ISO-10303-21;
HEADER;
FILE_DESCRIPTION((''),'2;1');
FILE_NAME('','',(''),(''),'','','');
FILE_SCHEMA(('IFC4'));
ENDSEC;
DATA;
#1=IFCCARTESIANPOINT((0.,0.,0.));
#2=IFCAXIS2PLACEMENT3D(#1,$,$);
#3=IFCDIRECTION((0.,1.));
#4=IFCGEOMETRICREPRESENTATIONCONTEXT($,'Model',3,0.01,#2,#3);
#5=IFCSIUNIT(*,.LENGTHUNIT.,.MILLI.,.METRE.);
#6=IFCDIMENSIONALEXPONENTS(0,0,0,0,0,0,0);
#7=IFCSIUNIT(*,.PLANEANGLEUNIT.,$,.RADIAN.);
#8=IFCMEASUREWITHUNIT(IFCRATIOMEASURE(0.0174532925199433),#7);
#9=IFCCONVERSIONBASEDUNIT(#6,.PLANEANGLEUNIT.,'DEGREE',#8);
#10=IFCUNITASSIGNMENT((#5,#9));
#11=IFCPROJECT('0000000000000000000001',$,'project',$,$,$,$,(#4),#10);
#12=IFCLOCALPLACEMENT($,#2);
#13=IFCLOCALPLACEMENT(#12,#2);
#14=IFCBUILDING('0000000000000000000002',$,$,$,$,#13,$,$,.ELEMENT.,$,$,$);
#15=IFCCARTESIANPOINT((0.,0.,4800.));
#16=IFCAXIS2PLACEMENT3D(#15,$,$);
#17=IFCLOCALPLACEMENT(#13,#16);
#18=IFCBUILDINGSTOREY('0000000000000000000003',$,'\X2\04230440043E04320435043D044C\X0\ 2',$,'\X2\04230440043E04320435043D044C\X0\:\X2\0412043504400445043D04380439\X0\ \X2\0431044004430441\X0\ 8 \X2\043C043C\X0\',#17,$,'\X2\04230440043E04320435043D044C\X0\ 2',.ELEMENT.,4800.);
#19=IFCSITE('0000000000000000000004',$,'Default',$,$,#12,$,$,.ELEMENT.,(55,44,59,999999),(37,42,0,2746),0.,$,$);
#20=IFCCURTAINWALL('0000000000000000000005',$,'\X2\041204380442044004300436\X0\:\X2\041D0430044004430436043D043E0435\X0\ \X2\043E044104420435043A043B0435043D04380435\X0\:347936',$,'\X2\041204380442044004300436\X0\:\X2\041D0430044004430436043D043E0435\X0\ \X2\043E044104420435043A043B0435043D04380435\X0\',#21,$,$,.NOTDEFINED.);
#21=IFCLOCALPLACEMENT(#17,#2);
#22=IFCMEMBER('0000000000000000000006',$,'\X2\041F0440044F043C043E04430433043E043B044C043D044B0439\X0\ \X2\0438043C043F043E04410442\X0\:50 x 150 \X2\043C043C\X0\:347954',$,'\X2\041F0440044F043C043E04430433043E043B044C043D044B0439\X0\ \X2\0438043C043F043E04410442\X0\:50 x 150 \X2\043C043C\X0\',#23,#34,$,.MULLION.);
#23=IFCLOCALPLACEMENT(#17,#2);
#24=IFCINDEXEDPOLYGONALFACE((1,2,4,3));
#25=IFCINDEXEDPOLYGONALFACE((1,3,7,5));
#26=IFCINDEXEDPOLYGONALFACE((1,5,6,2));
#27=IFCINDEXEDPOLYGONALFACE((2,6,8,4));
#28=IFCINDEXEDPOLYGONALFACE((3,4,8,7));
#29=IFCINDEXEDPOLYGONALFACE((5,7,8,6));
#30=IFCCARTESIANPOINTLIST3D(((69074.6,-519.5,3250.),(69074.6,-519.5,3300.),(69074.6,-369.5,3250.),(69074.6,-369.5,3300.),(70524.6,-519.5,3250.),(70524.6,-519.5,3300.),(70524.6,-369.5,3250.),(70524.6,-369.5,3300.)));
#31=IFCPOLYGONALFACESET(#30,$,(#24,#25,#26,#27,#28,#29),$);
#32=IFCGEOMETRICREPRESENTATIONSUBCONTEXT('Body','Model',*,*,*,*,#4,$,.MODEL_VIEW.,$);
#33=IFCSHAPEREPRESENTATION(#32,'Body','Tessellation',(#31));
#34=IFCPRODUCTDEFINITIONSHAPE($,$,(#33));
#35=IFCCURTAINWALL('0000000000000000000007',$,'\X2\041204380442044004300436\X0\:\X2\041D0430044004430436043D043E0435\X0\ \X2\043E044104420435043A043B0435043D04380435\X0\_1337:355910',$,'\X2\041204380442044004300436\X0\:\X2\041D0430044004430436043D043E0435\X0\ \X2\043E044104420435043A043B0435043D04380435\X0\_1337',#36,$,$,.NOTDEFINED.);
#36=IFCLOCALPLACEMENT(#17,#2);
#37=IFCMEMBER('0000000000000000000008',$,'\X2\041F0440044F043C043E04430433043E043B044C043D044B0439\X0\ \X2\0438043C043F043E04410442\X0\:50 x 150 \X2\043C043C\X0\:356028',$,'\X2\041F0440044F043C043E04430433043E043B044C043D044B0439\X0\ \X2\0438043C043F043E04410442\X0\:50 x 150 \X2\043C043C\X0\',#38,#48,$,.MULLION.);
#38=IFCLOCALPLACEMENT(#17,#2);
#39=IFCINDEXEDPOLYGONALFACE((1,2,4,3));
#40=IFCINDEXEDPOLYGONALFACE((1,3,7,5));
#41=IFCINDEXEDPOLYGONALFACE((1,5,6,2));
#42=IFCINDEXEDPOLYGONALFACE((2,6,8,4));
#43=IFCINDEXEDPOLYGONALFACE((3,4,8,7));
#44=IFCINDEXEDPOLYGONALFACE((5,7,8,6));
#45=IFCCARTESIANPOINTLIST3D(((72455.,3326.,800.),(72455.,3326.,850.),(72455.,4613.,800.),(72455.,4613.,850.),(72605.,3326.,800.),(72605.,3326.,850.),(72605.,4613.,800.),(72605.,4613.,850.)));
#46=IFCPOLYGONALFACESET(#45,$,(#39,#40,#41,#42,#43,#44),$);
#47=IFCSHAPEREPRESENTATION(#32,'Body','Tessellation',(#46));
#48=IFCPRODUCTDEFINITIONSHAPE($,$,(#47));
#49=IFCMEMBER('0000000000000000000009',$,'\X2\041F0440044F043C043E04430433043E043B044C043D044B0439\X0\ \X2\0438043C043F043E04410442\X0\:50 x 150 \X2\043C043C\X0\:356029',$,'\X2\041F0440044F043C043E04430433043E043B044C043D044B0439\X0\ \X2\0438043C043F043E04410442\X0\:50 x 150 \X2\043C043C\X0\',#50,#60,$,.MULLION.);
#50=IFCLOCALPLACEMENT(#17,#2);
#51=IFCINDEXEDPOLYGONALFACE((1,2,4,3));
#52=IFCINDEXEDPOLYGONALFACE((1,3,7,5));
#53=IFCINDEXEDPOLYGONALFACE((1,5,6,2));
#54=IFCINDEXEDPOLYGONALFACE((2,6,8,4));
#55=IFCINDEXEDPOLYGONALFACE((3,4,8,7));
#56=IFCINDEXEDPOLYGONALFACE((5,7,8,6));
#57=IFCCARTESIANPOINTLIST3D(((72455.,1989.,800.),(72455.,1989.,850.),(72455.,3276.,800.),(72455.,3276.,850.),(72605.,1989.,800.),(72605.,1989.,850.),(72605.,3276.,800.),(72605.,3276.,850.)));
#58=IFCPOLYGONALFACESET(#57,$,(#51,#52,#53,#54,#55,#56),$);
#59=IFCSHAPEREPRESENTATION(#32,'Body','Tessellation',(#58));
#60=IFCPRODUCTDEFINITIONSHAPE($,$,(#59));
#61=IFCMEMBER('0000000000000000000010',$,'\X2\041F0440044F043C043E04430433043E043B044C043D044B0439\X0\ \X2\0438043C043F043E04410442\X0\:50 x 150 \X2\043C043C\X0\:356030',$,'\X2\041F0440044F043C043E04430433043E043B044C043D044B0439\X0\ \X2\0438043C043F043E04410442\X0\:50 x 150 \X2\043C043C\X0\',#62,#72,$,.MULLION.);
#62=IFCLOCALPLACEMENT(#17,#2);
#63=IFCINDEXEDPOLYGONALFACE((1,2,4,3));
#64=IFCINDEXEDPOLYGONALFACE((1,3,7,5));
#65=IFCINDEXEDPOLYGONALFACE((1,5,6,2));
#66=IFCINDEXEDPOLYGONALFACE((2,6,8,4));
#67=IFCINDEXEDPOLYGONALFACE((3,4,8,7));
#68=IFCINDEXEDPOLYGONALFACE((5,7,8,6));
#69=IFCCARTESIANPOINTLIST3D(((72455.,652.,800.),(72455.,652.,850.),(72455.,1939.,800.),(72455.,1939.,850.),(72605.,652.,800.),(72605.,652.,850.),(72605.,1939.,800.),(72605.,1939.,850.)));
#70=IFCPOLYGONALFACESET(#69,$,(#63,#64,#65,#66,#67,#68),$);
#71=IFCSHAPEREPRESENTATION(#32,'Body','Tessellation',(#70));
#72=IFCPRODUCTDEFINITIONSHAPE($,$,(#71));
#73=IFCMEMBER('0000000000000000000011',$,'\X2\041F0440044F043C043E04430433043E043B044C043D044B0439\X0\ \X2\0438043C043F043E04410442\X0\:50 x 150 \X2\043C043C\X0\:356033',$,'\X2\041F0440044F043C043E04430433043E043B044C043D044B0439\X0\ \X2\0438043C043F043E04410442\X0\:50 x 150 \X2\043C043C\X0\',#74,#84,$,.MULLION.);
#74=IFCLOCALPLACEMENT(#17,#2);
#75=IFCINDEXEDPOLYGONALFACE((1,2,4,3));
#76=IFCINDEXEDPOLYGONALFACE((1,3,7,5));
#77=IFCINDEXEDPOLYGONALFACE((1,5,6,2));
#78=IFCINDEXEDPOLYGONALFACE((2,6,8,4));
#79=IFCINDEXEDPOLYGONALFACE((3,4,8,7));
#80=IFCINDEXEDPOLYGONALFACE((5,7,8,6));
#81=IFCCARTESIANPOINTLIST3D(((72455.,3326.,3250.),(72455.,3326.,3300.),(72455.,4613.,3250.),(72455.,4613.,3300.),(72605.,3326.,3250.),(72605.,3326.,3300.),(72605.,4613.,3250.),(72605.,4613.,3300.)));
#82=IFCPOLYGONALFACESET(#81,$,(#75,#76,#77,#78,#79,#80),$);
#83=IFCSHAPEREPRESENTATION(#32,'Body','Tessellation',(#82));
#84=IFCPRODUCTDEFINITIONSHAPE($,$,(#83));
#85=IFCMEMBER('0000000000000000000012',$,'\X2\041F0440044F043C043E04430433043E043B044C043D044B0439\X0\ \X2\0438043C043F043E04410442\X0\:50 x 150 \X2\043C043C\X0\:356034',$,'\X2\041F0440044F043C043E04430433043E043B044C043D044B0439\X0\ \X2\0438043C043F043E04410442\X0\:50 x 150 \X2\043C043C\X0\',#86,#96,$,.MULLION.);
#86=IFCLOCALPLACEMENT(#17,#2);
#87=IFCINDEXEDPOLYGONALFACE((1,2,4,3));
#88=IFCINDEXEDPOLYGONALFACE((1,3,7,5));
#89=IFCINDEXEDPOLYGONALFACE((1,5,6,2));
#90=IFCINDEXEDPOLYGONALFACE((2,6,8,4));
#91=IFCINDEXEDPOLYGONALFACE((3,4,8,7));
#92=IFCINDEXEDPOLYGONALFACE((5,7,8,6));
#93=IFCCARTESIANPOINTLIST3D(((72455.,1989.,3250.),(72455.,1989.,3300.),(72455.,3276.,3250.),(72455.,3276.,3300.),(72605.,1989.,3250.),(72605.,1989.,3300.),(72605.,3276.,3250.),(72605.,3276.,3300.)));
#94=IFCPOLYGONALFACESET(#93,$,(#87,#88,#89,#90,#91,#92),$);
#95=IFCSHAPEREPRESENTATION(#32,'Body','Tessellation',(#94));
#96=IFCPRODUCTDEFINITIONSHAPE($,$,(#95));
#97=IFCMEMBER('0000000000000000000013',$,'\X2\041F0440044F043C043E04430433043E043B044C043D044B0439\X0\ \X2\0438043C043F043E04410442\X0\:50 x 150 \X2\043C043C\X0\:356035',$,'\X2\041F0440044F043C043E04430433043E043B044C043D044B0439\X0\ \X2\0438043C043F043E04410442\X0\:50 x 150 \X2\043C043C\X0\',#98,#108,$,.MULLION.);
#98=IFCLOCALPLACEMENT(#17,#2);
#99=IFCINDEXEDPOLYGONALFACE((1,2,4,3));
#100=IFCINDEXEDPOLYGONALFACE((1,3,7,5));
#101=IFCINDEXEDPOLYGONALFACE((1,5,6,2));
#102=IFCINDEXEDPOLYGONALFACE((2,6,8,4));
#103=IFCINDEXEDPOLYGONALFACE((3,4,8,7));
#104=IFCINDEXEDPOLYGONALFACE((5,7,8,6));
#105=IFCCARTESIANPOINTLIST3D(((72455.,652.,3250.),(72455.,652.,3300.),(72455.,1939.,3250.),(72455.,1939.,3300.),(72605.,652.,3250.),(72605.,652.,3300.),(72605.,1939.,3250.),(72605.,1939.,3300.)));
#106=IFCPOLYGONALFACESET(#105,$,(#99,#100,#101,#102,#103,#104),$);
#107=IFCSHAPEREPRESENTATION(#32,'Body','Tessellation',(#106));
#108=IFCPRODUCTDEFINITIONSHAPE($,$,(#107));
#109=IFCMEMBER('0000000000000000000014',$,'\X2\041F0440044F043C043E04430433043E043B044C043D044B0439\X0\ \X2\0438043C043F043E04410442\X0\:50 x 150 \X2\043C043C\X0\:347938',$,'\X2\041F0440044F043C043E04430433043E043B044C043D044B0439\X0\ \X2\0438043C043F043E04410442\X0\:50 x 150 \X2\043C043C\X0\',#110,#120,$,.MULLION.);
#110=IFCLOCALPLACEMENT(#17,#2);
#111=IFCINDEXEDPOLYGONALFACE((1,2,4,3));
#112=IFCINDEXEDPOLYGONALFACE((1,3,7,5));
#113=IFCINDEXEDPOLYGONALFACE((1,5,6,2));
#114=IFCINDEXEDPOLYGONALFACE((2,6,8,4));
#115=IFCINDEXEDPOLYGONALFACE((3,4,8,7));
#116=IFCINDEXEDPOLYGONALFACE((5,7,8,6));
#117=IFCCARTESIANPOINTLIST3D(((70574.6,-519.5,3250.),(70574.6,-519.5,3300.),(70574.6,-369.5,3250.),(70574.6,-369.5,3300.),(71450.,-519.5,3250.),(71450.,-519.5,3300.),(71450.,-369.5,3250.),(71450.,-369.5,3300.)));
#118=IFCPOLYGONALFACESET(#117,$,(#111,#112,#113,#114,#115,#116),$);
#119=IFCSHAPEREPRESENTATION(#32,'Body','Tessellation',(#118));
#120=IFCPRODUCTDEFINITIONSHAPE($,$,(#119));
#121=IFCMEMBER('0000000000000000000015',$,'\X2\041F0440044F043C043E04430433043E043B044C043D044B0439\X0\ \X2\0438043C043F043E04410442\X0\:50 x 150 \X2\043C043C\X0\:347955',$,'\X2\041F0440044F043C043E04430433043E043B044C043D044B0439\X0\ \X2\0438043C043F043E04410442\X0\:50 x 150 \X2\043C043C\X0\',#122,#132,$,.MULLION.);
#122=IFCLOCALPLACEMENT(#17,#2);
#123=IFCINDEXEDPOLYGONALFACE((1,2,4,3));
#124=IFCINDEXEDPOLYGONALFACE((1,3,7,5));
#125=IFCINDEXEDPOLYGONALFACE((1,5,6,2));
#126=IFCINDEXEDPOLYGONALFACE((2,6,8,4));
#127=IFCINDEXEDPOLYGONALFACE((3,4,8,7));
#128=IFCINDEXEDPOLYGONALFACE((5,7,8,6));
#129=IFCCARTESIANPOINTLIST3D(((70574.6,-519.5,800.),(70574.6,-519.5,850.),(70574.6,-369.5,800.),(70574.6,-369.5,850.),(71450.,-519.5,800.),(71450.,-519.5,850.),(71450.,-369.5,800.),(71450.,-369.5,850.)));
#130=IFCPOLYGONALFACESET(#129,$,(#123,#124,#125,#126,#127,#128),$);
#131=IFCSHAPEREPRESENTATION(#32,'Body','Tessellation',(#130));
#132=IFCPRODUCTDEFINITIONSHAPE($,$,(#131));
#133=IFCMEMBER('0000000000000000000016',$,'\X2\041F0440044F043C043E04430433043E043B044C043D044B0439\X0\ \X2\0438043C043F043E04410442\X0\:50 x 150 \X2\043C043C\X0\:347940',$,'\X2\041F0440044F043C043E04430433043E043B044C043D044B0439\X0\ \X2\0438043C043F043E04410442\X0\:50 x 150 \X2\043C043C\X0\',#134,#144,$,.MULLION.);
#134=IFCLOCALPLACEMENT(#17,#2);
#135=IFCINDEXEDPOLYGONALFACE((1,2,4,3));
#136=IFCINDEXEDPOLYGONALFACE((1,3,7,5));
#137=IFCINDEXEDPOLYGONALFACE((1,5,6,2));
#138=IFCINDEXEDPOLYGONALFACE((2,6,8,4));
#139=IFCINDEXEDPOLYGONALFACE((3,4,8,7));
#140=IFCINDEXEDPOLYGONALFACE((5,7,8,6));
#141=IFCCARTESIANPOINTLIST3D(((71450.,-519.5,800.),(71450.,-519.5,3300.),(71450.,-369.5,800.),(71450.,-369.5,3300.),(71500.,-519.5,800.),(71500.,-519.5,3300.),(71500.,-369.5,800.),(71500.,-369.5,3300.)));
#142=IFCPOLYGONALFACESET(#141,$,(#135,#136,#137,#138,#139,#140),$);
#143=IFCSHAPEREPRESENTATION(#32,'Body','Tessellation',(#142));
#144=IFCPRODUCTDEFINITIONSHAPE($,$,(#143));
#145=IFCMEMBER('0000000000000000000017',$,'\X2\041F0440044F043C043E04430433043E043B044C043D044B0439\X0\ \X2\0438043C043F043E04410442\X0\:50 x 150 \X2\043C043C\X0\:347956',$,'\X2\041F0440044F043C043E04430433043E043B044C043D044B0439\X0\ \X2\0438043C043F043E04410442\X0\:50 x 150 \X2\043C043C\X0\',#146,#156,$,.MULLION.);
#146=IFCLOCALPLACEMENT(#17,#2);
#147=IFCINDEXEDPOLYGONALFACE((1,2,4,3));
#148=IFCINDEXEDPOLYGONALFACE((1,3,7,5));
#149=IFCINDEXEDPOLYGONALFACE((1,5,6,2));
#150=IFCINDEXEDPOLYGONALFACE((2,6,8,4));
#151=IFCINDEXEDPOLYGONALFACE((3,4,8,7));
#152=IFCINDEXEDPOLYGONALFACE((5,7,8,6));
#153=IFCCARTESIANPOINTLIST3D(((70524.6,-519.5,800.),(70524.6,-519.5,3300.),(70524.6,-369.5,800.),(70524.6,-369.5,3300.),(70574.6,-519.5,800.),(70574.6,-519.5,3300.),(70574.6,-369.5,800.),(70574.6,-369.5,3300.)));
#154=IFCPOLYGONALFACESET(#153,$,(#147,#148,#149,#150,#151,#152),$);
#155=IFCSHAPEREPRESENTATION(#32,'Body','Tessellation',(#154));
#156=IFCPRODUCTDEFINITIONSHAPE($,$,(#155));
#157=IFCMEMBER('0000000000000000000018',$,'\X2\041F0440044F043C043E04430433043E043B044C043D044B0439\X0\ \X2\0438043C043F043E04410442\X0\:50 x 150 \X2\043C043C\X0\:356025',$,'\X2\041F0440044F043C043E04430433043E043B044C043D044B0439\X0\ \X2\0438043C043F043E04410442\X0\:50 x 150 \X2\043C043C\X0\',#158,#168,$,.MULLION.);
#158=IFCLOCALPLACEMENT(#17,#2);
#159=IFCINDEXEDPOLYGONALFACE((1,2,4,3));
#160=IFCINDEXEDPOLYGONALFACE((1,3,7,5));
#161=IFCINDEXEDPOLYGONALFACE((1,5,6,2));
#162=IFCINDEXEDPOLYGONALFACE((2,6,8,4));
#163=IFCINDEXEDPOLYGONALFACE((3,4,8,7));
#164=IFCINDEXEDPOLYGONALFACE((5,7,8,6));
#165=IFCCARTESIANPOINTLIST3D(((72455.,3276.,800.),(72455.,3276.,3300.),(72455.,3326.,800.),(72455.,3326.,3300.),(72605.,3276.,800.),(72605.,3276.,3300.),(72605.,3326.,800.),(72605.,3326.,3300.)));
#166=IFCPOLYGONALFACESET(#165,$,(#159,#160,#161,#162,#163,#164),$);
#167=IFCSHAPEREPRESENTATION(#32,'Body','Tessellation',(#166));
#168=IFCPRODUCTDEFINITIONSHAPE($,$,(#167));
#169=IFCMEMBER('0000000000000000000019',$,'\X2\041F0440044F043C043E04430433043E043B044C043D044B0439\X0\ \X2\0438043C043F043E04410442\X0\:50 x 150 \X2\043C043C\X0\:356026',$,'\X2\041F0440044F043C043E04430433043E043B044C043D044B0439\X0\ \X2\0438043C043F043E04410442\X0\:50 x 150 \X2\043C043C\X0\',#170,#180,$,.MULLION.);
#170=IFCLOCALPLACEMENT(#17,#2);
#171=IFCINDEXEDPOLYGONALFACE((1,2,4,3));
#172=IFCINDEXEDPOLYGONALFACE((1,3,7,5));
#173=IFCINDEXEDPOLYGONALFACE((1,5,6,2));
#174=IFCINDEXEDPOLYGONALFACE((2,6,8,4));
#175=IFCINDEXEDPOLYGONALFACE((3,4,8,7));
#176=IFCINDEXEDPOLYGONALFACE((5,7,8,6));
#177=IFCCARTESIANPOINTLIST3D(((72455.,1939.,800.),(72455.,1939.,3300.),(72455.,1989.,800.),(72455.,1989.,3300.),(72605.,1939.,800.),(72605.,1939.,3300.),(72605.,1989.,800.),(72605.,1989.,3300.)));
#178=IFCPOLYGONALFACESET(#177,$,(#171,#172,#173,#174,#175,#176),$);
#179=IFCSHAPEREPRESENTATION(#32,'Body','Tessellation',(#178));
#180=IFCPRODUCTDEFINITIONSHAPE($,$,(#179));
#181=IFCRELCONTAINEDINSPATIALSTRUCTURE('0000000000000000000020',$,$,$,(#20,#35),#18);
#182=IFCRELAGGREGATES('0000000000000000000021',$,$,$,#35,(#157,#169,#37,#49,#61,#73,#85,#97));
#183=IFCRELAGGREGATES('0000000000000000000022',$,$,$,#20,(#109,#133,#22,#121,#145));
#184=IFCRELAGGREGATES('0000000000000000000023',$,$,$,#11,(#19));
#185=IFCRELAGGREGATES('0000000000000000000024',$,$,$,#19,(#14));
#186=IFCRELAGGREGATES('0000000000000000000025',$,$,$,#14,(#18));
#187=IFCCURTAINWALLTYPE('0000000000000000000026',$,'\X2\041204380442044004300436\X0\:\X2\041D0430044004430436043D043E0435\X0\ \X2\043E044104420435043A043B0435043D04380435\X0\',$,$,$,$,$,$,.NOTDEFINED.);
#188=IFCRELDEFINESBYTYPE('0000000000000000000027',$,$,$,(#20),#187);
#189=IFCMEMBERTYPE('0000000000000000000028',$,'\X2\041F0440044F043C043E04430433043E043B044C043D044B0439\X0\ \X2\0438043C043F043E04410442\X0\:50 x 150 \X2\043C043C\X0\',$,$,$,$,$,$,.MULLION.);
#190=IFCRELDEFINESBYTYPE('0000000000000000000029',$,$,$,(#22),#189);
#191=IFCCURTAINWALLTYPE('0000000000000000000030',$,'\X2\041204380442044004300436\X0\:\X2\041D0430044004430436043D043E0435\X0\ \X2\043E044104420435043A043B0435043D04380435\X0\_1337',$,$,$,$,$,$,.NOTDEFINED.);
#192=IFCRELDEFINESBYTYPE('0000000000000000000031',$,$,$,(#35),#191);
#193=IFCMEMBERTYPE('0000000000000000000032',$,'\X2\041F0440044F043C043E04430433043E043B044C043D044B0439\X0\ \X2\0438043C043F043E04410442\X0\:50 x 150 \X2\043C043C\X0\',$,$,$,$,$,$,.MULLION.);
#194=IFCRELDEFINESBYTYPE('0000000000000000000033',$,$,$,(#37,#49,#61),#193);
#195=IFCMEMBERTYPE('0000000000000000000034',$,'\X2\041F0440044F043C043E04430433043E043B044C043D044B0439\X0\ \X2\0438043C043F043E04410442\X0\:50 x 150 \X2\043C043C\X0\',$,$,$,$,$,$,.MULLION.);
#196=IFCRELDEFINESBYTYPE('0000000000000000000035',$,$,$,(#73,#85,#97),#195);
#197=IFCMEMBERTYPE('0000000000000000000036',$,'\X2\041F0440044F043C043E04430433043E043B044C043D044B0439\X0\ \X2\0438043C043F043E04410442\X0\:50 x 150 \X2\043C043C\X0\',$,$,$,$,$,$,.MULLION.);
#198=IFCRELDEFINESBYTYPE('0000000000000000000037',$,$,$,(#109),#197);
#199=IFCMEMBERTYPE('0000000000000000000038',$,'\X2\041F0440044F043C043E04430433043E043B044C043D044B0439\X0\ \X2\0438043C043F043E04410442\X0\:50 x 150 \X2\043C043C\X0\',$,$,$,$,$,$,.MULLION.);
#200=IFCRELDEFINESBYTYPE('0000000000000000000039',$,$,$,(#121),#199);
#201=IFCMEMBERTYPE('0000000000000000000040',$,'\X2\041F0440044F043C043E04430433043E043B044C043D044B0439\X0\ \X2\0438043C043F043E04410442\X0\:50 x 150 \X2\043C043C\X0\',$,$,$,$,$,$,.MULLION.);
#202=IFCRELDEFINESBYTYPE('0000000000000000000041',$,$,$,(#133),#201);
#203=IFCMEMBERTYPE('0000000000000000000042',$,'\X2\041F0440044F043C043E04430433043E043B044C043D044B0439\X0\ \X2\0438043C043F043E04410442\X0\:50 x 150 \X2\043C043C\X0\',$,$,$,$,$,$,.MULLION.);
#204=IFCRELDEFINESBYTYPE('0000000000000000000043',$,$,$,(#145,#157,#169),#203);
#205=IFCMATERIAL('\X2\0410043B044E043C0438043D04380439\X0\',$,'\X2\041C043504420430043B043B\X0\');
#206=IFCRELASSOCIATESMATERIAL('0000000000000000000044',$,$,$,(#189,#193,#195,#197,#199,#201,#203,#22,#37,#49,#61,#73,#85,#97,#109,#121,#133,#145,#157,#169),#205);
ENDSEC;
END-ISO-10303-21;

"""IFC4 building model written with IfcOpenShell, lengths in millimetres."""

from ifc_helpers import new_model, entity, si_unit, converted_unit, direction, frame, origin, origin_2d_with_axis, place, context, subcontext, project, spatial, rectangle, extrude, source, transform, mapped, material, material_profile, profile_set, profile_usage, type_object, type_shapes, element, aggregate, save


model = new_model("IFC4")

# Units and contexts
model_context = context("Model", 3, precision=0.01, world=origin(), true_north=direction((0.0, 1.0)))
body_context = subcontext(model_context, "Body", "Model", "MODEL_VIEW")
ifc_project = project(units=[si_unit("LENGTHUNIT", "METRE", prefix="MILLI"), converted_unit("PLANEANGLEUNIT", "DEGREE", entity("IfcRatioMeasure", 0.0174532925199433), si_unit("PLANEANGLEUNIT", "RADIAN"), dimensions=[0, 0, 0, 0, 0, 0, 0])], contexts=[model_context])

# Site, building, storey
site_placement = place(None, origin())
site = spatial("IfcSite", under=ifc_project, at=site_placement, Name="Default", CompositionType="ELEMENT", RefLatitude=(55, 44, 59, 999999), RefLongitude=(37, 42, 0, 2746), RefElevation=0.0)
building_placement = place(site_placement, origin())
building = spatial("IfcBuilding", under=site, at=building_placement, CompositionType="ELEMENT")
storey_placement = place(building_placement, frame((0.0, 0.0, 4800.0)))
storey = spatial("IfcBuildingStorey", under=building, at=storey_placement, Name="Уровень 2", ObjectType="Уровень:Верхний брус 8 мм", LongName="Уровень 2", CompositionType="ELEMENT", Elevation=4800.0)

# Curtain wall, member
curtain_wall_type_1 = type_object("IfcCurtainWallType", Name="Витраж:Наружное остекление", PredefinedType="NOTDEFINED")
curtain_wall_1_placement = place(storey_placement, frame((0.0, 0.0, -4800.0)))
curtain_wall_1 = element("IfcCurtainWall", 1, at=curtain_wall_1_placement, inside=storey, type_object=curtain_wall_type_1, Name="Витраж:Наружное остекление:347936", ObjectType="Витраж:Наружное остекление", PredefinedType="NOTDEFINED")
ifc_material_1 = material(Name="Алюминий", Category="Металл")
ifc_material_profile = material_profile(ifc_material_1, rectangle(XDim=150.0, YDim=50.0, at=origin_2d_with_axis()), Name="50 x 150 мм")
ifc_profile_set = profile_set([ifc_material_profile], Name="50 x 150 мм")
ifc_profile_usage_1 = profile_usage(ifc_profile_set)
member_type_1 = type_object("IfcMemberType", Name="Прямоугольный импост:50 x 150 мм", PredefinedType="MULLION", material=ifc_profile_set)
shared_shape_1 = source(origin(), body_context, "Body", "SweptSolid", [
    extrude(rectangle(XDim=150.0, YDim=50.0, at=origin_2d_with_axis()), frame((-25.0, 0.0, -1450.0), z_axis=(0.0, 0.0, 1.0), x_axis=(0.0, -1.0, 0.0)), (0.0, 0.0, 1.0), 1450.0),
])
type_shapes(member_type_1, [shared_shape_1])
member_1_placement = place(storey_placement, frame((70524.6, -444.5, 3300.0), z_axis=(1.0, 0.0, 0.0), x_axis=(0.0, 0.0, 1.0)))
member_1 = element("IfcMember", 2, at=member_1_placement, type_object=member_type_1, material=ifc_profile_usage_1, Name="Прямоугольный импост:50 x 150 мм:347954", ObjectType="Прямоугольный импост:50 x 150 мм", PredefinedType="MULLION", context=body_context, shape_type="MappedRepresentation", body=[
    mapped(shared_shape_1, transform((0.0, 0.0, 0.0), scale=1.0)),
])

# Curtain wall, members
curtain_wall_type_2 = type_object("IfcCurtainWallType", Name="Витраж:Наружное остекление_1337", PredefinedType="NOTDEFINED")
curtain_wall_2_placement = place(storey_placement, frame((0.0, 0.0, -4800.0)))
curtain_wall_2 = element("IfcCurtainWall", 3, at=curtain_wall_2_placement, inside=storey, type_object=curtain_wall_type_2, Name="Витраж:Наружное остекление_1337:355910", ObjectType="Витраж:Наружное остекление_1337", PredefinedType="NOTDEFINED")
ifc_profile_usage_2 = profile_usage(ifc_profile_set)
member_type_2 = type_object("IfcMemberType", Name="Прямоугольный импост:50 x 150 мм", PredefinedType="MULLION", material=ifc_profile_set)
shared_shape_2 = source(origin(), body_context, "Body", "SweptSolid", [
    extrude(rectangle(XDim=150.0, YDim=50.0, at=origin_2d_with_axis()), frame((-25.0, 0.0, -1287.0), z_axis=(0.0, 0.0, 1.0), x_axis=(0.0, -1.0, 0.0)), (0.0, 0.0, 1.0), 1287.0),
])
type_shapes(member_type_2, [shared_shape_2])
member_2_placement = place(storey_placement, frame((72530.0, 4613.0, 800.0), z_axis=(0.0, 1.0, 0.0), x_axis=(0.0, 0.0, -1.0)))
member_2 = element("IfcMember", 4, at=member_2_placement, type_object=member_type_2, material=ifc_profile_usage_2, Name="Прямоугольный импост:50 x 150 мм:356028", ObjectType="Прямоугольный импост:50 x 150 мм", PredefinedType="MULLION", context=body_context, shape_type="MappedRepresentation", body=[
    mapped(shared_shape_2, transform((0.0, 0.0, 0.0), scale=1.0)),
])
ifc_profile_usage_3 = profile_usage(ifc_profile_set)
member_3_placement = place(storey_placement, frame((72530.0, 3276.0, 800.0), z_axis=(0.0, 1.0, 0.0), x_axis=(0.0, 0.0, -1.0)))
member_3 = element("IfcMember", 5, at=member_3_placement, type_object=member_type_2, material=ifc_profile_usage_3, Name="Прямоугольный импост:50 x 150 мм:356029", ObjectType="Прямоугольный импост:50 x 150 мм", PredefinedType="MULLION", context=body_context, shape_type="MappedRepresentation", body=[
    mapped(shared_shape_2, transform((0.0, 0.0, 0.0), scale=1.0)),
])
ifc_profile_usage_4 = profile_usage(ifc_profile_set)
member_4_placement = place(storey_placement, frame((72530.0, 1939.0, 800.0), z_axis=(0.0, 1.0, 0.0), x_axis=(0.0, 0.0, -1.0)))
member_4 = element("IfcMember", 6, at=member_4_placement, type_object=member_type_2, material=ifc_profile_usage_4, Name="Прямоугольный импост:50 x 150 мм:356030", ObjectType="Прямоугольный импост:50 x 150 мм", PredefinedType="MULLION", context=body_context, shape_type="MappedRepresentation", body=[
    mapped(shared_shape_2, transform((0.0, 0.0, 0.0), scale=1.0)),
])
ifc_profile_usage_5 = profile_usage(ifc_profile_set)
member_type_3 = type_object("IfcMemberType", Name="Прямоугольный импост:50 x 150 мм", PredefinedType="MULLION", material=ifc_profile_set)
shared_shape_3 = source(origin(), body_context, "Body", "SweptSolid", [
    extrude(rectangle(XDim=150.0, YDim=50.0, at=origin_2d_with_axis()), frame((-25.0, 0.0, -1287.0), z_axis=(0.0, 0.0, 1.0), x_axis=(0.0, -1.0, 0.0)), (0.0, 0.0, 1.0), 1287.0),
])
type_shapes(member_type_3, [shared_shape_3])
member_5_placement = place(storey_placement, frame((72530.0, 3326.0, 3300.0), z_axis=(0.0, -1.0, 0.0), x_axis=(0.0, 0.0, 1.0)))
member_5 = element("IfcMember", 7, at=member_5_placement, type_object=member_type_3, material=ifc_profile_usage_5, Name="Прямоугольный импост:50 x 150 мм:356033", ObjectType="Прямоугольный импост:50 x 150 мм", PredefinedType="MULLION", context=body_context, shape_type="MappedRepresentation", body=[
    mapped(shared_shape_3, transform((0.0, 0.0, 0.0), scale=1.0)),
])
ifc_profile_usage_6 = profile_usage(ifc_profile_set)
member_6_placement = place(storey_placement, frame((72530.0, 1989.0, 3300.0), z_axis=(0.0, -1.0, 0.0), x_axis=(0.0, 0.0, 1.0)))
member_6 = element("IfcMember", 8, at=member_6_placement, type_object=member_type_3, material=ifc_profile_usage_6, Name="Прямоугольный импост:50 x 150 мм:356034", ObjectType="Прямоугольный импост:50 x 150 мм", PredefinedType="MULLION", context=body_context, shape_type="MappedRepresentation", body=[
    mapped(shared_shape_3, transform((0.0, 0.0, 0.0), scale=1.0)),
])
ifc_profile_usage_7 = profile_usage(ifc_profile_set)
member_7_placement = place(storey_placement, frame((72530.0, 652.0, 3300.0), z_axis=(0.0, -1.0, 0.0), x_axis=(0.0, 0.0, 1.0)))
member_7 = element("IfcMember", 9, at=member_7_placement, type_object=member_type_3, material=ifc_profile_usage_7, Name="Прямоугольный импост:50 x 150 мм:356035", ObjectType="Прямоугольный импост:50 x 150 мм", PredefinedType="MULLION", context=body_context, shape_type="MappedRepresentation", body=[
    mapped(shared_shape_3, transform((0.0, 0.0, 0.0), scale=1.0)),
])

# Members
ifc_profile_usage_8 = profile_usage(ifc_profile_set)
member_type_4 = type_object("IfcMemberType", Name="Прямоугольный импост:50 x 150 мм", PredefinedType="MULLION", material=ifc_profile_set)
shared_shape_4 = source(origin(), body_context, "Body", "SweptSolid", [
    extrude(rectangle(XDim=150.0, YDim=50.0, at=origin_2d_with_axis()), frame((-25.0, 0.0, -875.4), z_axis=(0.0, 0.0, 1.0), x_axis=(0.0, -1.0, 0.0)), (0.0, 0.0, 1.0), 875.4),
])
type_shapes(member_type_4, [shared_shape_4])
member_8_placement = place(storey_placement, frame((71450.0, -444.5, 3300.0), z_axis=(1.0, 0.0, 0.0), x_axis=(0.0, 0.0, 1.0)))
member_8 = element("IfcMember", 10, at=member_8_placement, type_object=member_type_4, material=ifc_profile_usage_8, Name="Прямоугольный импост:50 x 150 мм:347938", ObjectType="Прямоугольный импост:50 x 150 мм", PredefinedType="MULLION", context=body_context, shape_type="MappedRepresentation", body=[
    mapped(shared_shape_4, transform((0.0, 0.0, 0.0), scale=1.0)),
])
ifc_profile_usage_9 = profile_usage(ifc_profile_set)
member_type_5 = type_object("IfcMemberType", Name="Прямоугольный импост:50 x 150 мм", PredefinedType="MULLION", material=ifc_profile_set)
shared_shape_5 = source(origin(), body_context, "Body", "SweptSolid", [
    extrude(rectangle(XDim=150.0, YDim=50.0, at=origin_2d_with_axis()), frame((-25.0, 0.0, -875.4), z_axis=(0.0, 0.0, 1.0), x_axis=(0.0, -1.0, 0.0)), (0.0, 0.0, 1.0), 875.4),
])
type_shapes(member_type_5, [shared_shape_5])
member_9_placement = place(storey_placement, frame((70574.6, -444.5, 800.0), z_axis=(-1.0, 0.0, 0.0), x_axis=(0.0, 0.0, -1.0)))
member_9 = element("IfcMember", 11, at=member_9_placement, type_object=member_type_5, material=ifc_profile_usage_9, Name="Прямоугольный импост:50 x 150 мм:347955", ObjectType="Прямоугольный импост:50 x 150 мм", PredefinedType="MULLION", context=body_context, shape_type="MappedRepresentation", body=[
    mapped(shared_shape_5, transform((0.0, 0.0, 0.0), scale=1.0)),
])
ifc_profile_usage_10 = profile_usage(ifc_profile_set)
member_type_6 = type_object("IfcMemberType", Name="Прямоугольный импост:50 x 150 мм", PredefinedType="MULLION", material=ifc_profile_set)
shared_shape_6 = source(origin(), body_context, "Body", "SweptSolid", [
    extrude(rectangle(XDim=150.0, YDim=50.0, at=origin_2d_with_axis()), frame((-25.0, 0.0, -2500.0), z_axis=(0.0, 0.0, 1.0), x_axis=(0.0, -1.0, 0.0)), (0.0, 0.0, 1.0), 2500.0),
])
type_shapes(member_type_6, [shared_shape_6])
member_10_placement = place(storey_placement, frame((71500.0, -444.5, 800.0), z_axis=(0.0, 0.0, -1.0), x_axis=(1.0, 0.0, 0.0)))
member_10 = element("IfcMember", 12, at=member_10_placement, type_object=member_type_6, material=ifc_profile_usage_10, Name="Прямоугольный импост:50 x 150 мм:347940", ObjectType="Прямоугольный импост:50 x 150 мм", PredefinedType="MULLION", context=body_context, shape_type="MappedRepresentation", body=[
    mapped(shared_shape_6, transform((0.0, 0.0, 0.0), scale=1.0)),
])
ifc_profile_usage_11 = profile_usage(ifc_profile_set)
member_type_7 = type_object("IfcMemberType", Name="Прямоугольный импост:50 x 150 мм", PredefinedType="MULLION", material=ifc_profile_set)
shared_shape_7 = source(origin(), body_context, "Body", "SweptSolid", [
    extrude(rectangle(XDim=150.0, YDim=50.0, at=origin_2d_with_axis()), frame((0.0, 0.0, -2500.0), z_axis=(0.0, 0.0, 1.0), x_axis=(0.0, -1.0, 0.0)), (0.0, 0.0, 1.0), 2500.0),
])
type_shapes(member_type_7, [shared_shape_7])
member_11_placement = place(storey_placement, frame((70549.6, -444.5, 800.0), z_axis=(0.0, 0.0, -1.0), x_axis=(1.0, 0.0, 0.0)))
member_11 = element("IfcMember", 13, at=member_11_placement, type_object=member_type_7, material=ifc_profile_usage_11, Name="Прямоугольный импост:50 x 150 мм:347956", ObjectType="Прямоугольный импост:50 x 150 мм", PredefinedType="MULLION", context=body_context, shape_type="MappedRepresentation", body=[
    mapped(shared_shape_7, transform((0.0, 0.0, 0.0), scale=1.0)),
])
ifc_profile_usage_12 = profile_usage(ifc_profile_set)
member_12_placement = place(storey_placement, frame((72530.0, 3301.0, 800.0), z_axis=(0.0, 0.0, -1.0), x_axis=(0.0, -1.0, 0.0)))
member_12 = element("IfcMember", 14, at=member_12_placement, type_object=member_type_7, material=ifc_profile_usage_12, Name="Прямоугольный импост:50 x 150 мм:356025", ObjectType="Прямоугольный импост:50 x 150 мм", PredefinedType="MULLION", context=body_context, shape_type="MappedRepresentation", body=[
    mapped(shared_shape_7, transform((0.0, 0.0, 0.0), scale=1.0)),
])
ifc_profile_usage_13 = profile_usage(ifc_profile_set)
member_13_placement = place(storey_placement, frame((72530.0, 1964.0, 800.0), z_axis=(0.0, 0.0, -1.0), x_axis=(0.0, -1.0, 0.0)))
member_13 = element("IfcMember", 15, at=member_13_placement, type_object=member_type_7, material=ifc_profile_usage_13, Name="Прямоугольный импост:50 x 150 мм:356026", ObjectType="Прямоугольный импост:50 x 150 мм", PredefinedType="MULLION", context=body_context, shape_type="MappedRepresentation", body=[
    mapped(shared_shape_7, transform((0.0, 0.0, 0.0), scale=1.0)),
])

aggregate(curtain_wall_2, [member_12, member_13, member_2, member_3, member_4, member_5, member_6, member_7])
aggregate(curtain_wall_1, [member_8, member_10, member_1, member_9, member_11])

save(model, "model.ifc")
